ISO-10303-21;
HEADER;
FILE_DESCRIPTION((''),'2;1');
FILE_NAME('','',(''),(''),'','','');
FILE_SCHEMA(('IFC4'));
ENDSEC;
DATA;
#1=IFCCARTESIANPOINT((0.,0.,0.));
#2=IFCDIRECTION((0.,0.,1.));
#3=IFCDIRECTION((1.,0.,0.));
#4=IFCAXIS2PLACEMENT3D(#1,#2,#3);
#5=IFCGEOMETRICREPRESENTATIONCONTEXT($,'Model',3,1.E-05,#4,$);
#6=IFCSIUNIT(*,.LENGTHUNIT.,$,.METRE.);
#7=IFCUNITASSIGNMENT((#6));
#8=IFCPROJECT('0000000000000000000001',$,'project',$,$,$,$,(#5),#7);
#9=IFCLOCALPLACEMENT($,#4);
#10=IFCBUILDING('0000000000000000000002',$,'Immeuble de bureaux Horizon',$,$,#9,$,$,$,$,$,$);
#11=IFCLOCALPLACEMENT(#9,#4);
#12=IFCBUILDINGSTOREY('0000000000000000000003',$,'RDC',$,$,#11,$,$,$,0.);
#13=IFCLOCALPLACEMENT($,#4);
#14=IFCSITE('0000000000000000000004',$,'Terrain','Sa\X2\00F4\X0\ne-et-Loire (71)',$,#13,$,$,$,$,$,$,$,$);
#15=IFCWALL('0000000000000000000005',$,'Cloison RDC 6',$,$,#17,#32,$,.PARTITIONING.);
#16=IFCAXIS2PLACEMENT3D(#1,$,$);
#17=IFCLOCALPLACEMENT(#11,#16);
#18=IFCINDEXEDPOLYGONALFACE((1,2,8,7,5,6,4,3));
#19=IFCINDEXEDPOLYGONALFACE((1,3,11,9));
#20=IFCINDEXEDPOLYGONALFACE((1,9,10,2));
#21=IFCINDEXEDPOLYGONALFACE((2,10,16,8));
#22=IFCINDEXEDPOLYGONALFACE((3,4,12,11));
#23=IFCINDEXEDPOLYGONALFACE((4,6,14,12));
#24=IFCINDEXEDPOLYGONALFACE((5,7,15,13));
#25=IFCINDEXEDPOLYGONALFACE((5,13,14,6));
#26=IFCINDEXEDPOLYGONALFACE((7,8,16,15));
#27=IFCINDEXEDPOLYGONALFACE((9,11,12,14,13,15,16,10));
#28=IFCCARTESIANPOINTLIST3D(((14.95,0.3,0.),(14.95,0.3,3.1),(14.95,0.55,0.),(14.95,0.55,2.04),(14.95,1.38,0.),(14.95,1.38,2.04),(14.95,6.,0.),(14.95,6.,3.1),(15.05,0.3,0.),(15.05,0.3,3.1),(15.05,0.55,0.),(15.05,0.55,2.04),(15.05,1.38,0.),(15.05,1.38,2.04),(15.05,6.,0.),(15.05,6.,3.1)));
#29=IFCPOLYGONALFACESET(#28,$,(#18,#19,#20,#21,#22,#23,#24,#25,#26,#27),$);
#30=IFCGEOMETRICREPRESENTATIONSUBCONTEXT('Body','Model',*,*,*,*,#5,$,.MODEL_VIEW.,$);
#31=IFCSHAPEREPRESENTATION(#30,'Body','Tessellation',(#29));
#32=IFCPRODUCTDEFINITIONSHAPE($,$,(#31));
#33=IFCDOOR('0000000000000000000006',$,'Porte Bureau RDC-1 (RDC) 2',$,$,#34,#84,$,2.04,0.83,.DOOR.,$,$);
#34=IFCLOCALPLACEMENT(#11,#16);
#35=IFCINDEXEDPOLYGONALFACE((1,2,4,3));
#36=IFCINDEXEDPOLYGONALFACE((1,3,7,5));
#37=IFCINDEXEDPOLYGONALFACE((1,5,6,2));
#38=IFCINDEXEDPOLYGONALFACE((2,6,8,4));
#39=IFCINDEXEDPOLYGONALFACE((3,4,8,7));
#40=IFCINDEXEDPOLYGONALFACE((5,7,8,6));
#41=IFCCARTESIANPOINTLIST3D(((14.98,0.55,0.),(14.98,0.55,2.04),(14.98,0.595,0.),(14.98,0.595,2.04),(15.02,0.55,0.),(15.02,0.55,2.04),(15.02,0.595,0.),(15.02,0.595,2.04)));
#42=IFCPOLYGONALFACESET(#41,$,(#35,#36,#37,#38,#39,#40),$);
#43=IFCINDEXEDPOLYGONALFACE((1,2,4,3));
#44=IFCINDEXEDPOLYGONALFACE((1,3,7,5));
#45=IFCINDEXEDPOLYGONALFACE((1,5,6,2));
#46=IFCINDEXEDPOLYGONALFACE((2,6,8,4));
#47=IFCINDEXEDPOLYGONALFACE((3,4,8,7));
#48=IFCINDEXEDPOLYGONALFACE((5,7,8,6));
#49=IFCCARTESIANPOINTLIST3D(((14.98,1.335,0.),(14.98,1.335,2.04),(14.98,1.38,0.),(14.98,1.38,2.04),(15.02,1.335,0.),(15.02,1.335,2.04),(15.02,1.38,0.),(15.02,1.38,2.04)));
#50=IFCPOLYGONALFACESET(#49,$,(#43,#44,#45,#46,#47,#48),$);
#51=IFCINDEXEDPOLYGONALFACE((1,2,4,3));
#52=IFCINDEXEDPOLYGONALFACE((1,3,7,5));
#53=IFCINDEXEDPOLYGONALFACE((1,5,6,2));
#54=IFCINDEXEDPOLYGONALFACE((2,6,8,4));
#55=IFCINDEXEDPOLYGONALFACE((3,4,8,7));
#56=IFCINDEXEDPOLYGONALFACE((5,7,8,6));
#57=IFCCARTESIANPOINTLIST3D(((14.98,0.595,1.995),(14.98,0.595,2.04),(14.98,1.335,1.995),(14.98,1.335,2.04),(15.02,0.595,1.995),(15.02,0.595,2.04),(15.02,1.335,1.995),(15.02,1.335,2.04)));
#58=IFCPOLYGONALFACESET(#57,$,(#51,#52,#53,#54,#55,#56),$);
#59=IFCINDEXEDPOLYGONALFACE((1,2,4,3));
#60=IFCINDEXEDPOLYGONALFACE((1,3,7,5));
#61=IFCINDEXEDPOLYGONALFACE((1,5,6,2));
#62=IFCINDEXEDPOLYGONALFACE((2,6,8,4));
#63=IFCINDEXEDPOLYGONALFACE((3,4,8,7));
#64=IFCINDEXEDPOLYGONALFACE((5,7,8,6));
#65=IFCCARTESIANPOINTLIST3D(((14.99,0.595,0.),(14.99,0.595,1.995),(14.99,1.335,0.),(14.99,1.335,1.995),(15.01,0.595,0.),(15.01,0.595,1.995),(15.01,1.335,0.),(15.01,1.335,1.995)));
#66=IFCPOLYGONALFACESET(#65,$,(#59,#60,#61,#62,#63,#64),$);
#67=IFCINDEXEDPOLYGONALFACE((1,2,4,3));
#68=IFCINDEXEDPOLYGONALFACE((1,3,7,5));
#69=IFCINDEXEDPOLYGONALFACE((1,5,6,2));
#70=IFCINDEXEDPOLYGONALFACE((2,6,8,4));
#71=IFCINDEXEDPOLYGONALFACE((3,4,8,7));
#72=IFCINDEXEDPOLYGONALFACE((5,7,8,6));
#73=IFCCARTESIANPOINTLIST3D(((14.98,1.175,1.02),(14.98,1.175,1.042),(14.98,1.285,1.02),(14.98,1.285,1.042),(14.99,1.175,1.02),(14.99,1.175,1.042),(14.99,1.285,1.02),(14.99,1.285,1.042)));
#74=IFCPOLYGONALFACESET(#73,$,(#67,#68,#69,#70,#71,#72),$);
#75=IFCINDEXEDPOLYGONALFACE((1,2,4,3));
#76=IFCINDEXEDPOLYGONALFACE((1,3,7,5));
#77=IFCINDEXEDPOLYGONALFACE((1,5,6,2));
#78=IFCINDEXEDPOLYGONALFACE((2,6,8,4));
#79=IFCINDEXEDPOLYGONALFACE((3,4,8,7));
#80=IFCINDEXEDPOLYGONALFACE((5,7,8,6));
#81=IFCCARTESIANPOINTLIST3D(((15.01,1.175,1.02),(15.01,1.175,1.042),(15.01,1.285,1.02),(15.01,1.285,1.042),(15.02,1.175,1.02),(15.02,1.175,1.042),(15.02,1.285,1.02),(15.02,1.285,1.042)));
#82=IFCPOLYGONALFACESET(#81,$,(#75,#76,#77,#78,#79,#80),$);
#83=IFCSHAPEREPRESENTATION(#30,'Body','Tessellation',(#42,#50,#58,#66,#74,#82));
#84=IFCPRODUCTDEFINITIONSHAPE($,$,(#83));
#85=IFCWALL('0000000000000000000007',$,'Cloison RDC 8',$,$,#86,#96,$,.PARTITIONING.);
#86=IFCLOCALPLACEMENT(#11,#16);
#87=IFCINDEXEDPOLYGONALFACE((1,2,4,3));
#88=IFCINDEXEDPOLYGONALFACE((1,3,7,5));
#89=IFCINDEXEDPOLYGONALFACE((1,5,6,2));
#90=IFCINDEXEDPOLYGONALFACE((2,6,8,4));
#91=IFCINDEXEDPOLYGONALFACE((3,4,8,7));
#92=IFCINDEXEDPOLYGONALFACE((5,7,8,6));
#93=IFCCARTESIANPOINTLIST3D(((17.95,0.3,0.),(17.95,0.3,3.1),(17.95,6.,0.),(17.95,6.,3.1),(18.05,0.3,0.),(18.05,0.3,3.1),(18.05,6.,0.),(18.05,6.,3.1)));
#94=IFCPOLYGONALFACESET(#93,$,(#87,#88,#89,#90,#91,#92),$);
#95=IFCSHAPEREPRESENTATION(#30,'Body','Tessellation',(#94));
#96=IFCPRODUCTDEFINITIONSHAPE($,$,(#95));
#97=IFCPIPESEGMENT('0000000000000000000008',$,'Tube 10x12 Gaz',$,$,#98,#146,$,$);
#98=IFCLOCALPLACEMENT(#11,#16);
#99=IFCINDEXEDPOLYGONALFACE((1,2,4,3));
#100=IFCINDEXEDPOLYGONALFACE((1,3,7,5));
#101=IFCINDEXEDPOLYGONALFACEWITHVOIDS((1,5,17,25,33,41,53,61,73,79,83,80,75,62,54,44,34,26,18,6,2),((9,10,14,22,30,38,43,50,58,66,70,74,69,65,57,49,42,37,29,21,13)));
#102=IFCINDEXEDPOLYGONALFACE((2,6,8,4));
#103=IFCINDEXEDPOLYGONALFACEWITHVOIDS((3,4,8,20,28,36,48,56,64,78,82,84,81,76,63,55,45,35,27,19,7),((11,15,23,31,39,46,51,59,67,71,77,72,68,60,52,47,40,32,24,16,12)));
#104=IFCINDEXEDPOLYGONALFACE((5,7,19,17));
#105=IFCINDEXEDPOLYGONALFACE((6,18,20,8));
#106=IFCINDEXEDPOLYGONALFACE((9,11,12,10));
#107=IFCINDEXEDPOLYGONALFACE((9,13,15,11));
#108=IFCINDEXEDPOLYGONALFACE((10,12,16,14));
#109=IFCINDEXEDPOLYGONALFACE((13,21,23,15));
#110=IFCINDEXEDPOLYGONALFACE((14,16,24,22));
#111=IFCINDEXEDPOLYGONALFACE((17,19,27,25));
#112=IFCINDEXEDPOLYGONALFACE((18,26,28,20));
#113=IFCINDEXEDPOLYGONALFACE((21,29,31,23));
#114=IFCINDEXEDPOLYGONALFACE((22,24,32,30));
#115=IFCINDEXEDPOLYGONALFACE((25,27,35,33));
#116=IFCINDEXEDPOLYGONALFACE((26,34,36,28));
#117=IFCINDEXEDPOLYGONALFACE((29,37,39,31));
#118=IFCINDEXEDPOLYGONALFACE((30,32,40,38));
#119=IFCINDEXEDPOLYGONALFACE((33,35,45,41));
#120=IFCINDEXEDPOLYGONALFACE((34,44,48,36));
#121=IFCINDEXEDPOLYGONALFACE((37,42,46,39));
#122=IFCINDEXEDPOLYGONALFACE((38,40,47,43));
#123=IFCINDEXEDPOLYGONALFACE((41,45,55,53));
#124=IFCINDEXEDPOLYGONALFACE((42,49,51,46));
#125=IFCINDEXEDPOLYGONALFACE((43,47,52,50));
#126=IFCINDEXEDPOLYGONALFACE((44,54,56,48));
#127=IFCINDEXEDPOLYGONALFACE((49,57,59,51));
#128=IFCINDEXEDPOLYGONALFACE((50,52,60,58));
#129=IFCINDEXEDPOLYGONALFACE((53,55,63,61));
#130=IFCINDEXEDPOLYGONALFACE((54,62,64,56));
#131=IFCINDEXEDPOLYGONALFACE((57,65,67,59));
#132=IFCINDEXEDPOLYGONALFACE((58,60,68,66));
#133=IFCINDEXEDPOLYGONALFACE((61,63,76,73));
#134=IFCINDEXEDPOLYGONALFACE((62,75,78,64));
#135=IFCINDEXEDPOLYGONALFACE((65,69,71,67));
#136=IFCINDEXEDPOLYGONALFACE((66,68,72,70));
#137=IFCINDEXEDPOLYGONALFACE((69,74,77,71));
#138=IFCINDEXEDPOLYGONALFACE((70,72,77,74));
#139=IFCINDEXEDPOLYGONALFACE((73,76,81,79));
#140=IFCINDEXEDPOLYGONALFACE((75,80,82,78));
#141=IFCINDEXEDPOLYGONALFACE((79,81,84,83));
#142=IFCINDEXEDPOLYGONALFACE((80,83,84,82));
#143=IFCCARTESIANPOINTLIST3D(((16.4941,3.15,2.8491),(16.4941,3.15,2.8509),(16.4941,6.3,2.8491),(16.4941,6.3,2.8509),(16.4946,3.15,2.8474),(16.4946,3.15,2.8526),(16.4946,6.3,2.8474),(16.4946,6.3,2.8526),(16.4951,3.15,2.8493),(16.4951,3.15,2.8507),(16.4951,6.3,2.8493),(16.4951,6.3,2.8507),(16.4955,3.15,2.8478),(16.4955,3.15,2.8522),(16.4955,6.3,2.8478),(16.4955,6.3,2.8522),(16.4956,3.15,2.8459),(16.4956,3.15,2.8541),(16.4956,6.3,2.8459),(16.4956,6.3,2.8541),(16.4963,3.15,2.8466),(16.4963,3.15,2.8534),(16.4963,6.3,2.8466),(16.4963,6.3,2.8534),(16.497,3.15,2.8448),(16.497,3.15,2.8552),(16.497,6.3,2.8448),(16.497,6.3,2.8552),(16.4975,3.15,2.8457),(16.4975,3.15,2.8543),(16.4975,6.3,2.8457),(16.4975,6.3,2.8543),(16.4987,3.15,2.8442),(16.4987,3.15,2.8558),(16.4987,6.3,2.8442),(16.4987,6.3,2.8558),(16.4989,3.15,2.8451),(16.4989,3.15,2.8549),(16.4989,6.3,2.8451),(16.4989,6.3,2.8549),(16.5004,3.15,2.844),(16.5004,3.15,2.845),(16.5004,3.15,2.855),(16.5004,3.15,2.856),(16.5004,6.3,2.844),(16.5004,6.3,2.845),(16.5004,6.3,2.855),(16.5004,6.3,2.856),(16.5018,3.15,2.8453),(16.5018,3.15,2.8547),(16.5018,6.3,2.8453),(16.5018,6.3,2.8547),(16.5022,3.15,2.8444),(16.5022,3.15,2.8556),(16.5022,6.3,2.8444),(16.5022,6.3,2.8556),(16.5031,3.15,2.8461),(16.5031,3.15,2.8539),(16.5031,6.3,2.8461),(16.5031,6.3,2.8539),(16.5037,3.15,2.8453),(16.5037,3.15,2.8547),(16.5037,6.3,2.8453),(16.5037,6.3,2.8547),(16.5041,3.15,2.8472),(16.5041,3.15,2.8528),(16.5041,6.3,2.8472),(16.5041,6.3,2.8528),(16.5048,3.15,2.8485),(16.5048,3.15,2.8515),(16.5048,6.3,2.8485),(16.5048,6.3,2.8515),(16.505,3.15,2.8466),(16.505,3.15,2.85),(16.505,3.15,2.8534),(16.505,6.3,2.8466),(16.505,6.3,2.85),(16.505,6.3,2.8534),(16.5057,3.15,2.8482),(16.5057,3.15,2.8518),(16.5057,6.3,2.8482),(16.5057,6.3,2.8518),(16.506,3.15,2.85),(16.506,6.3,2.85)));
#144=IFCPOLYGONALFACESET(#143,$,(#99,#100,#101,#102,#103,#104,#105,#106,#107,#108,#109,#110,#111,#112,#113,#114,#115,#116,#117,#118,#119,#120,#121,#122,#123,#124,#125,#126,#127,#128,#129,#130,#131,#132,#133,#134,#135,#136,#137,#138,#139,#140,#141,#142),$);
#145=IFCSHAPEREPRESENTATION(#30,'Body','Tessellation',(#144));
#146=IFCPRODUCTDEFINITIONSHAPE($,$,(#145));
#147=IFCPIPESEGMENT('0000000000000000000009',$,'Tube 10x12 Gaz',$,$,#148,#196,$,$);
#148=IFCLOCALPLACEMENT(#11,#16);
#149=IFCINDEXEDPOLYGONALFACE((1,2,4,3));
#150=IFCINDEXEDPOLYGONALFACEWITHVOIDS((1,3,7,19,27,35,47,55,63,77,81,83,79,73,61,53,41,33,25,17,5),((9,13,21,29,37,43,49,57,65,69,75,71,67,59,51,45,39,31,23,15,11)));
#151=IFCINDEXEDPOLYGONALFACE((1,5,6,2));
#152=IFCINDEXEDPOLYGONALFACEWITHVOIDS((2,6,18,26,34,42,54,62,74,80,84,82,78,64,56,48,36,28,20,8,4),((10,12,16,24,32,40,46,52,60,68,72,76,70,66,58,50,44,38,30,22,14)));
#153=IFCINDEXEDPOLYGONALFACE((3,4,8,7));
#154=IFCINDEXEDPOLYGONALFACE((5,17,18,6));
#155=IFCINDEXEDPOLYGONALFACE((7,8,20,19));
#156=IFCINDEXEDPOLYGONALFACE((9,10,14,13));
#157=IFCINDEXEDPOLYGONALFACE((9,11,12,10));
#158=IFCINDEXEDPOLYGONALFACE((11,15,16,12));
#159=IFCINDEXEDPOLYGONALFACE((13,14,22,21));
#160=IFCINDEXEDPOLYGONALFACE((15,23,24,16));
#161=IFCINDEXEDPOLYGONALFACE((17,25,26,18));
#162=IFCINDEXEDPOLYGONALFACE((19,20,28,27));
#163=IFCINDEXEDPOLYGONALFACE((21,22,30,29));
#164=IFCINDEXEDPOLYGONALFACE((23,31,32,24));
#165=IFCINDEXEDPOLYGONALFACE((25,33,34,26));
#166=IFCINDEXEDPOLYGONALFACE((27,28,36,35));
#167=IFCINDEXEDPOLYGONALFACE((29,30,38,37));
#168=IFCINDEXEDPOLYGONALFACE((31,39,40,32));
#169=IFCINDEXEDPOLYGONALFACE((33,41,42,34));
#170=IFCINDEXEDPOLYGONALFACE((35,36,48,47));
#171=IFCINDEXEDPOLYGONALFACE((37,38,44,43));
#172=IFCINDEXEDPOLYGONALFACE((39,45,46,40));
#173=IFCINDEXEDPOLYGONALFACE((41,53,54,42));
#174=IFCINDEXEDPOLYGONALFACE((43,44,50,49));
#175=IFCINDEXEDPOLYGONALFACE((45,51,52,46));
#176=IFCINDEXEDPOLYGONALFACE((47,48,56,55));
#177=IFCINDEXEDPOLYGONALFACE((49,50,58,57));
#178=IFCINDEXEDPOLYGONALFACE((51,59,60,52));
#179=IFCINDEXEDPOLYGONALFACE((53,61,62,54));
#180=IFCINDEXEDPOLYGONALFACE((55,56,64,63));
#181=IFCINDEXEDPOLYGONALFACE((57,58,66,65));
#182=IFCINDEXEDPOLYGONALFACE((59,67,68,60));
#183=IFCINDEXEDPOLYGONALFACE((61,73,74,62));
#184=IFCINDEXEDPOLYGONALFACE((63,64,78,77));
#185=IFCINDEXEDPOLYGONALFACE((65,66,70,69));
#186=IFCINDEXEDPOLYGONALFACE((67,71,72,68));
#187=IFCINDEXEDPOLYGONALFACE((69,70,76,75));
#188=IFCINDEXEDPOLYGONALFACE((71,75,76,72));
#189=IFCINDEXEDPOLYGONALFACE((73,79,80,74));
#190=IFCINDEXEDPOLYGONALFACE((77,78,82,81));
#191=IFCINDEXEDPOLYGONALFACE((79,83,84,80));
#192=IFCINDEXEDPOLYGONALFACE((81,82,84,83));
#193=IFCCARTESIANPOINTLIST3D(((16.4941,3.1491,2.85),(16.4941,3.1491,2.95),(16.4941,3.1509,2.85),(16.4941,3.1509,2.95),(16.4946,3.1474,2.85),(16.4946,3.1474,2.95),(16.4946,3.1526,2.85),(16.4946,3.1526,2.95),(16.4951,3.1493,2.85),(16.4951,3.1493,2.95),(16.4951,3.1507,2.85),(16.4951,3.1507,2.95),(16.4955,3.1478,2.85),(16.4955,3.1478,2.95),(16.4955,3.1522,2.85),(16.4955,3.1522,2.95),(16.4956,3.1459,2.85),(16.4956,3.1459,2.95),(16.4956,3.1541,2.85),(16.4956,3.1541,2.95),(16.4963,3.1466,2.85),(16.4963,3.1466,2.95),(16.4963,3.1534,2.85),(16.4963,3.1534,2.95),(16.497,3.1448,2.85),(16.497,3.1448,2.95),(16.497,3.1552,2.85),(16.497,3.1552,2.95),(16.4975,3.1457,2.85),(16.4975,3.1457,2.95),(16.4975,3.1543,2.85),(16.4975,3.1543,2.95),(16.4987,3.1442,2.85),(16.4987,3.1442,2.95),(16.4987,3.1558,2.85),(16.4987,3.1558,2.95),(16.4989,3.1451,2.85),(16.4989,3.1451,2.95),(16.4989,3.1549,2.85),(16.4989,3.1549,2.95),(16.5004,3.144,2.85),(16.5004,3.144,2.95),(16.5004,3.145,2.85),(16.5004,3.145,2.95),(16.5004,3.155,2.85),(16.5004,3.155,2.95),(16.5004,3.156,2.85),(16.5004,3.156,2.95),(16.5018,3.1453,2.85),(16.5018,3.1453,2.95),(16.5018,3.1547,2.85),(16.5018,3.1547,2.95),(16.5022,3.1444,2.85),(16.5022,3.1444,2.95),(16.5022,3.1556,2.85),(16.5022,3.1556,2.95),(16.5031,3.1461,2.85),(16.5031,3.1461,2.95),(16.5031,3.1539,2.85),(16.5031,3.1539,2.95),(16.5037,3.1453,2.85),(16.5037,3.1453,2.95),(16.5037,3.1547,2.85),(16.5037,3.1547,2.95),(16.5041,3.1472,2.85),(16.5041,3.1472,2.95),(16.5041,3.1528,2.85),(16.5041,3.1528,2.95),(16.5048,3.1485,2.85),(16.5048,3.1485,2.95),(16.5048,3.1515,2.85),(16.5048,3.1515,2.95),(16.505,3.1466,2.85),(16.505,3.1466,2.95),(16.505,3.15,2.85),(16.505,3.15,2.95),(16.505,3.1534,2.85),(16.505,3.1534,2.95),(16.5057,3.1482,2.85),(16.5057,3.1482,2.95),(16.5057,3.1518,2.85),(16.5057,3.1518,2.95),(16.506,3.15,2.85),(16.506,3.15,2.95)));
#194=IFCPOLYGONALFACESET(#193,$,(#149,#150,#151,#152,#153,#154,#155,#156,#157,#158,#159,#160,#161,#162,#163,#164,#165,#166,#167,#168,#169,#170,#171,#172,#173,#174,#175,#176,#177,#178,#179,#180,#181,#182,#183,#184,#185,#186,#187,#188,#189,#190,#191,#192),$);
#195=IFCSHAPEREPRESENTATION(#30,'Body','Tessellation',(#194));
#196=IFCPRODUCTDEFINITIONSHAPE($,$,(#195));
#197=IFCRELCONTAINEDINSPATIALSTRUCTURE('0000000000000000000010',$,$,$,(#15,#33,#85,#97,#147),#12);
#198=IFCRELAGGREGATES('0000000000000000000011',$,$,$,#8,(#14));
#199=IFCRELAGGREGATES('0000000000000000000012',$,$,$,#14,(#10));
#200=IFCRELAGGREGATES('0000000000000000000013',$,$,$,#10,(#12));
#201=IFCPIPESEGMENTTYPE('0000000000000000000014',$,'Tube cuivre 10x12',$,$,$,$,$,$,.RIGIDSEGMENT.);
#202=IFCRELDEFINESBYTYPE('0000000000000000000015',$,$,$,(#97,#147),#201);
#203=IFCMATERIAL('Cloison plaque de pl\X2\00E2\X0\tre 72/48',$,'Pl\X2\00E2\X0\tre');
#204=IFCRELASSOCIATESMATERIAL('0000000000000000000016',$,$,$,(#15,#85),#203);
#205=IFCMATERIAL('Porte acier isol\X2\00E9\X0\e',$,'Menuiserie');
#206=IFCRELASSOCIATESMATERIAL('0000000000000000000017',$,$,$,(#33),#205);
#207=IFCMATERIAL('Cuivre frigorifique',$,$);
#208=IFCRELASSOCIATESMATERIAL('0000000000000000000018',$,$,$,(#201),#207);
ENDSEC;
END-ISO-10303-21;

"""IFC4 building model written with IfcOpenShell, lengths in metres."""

from ifc_helpers import new_model, si_unit, frame, frame_2d, origin_with_axes, place, context, subcontext, project, spatial, rectangle, hollow_circle, extrude, material, type_object, element, fill, save


model = new_model("IFC4")

# Units and contexts
model_context = context("Model", 3, precision=1e-05, world=origin_with_axes())
body_context = subcontext(model_context, "Body", "Model", "MODEL_VIEW")
ifc_project = project(units=[si_unit("LENGTHUNIT", "METRE")], contexts=[model_context])

# Site, building, storey
site_placement = place(None, origin_with_axes())
site = spatial("IfcSite", under=ifc_project, at=site_placement, Name="Terrain", Description="Saône-et-Loire (71)")
building_placement = place(None, origin_with_axes())
building = spatial("IfcBuilding", under=site, at=building_placement, Name="Immeuble de bureaux Horizon")
storey_placement = place(building_placement, origin_with_axes())
storey = spatial("IfcBuildingStorey", under=building, at=storey_placement, Name="RDC", Elevation=0.0)

# Wall, opening, door
ifc_material_1 = material(Name="Cloison plaque de plâtre 72/48", Category="Plâtre")
wall_1_placement = place(storey_placement, frame((14.95, 0.3, 0.0), z_axis=(0.0, 0.0, 1.0), x_axis=(1.0, 0.0, 0.0)))
wall_1 = element("IfcWall", 1, at=wall_1_placement, inside=storey, material=ifc_material_1, Name="Cloison RDC 6", PredefinedType="PARTITIONING", context=body_context, shape_type="SweptSolid", body=[
    extrude(rectangle(XDim=0.1, YDim=5.7, at=frame_2d((0.05, 2.85))), origin_with_axes(), (0.0, 0.0, 1.0), 3.1),
])
opening_placement = place(storey_placement, frame((14.9, 0.55, 0.0), z_axis=(0.0, 0.0, 1.0), x_axis=(1.0, 0.0, 0.0)))
opening = element("IfcOpeningElement", 2, at=opening_placement, cuts=wall_1, context=body_context, shape_type="SweptSolid", body=[
    extrude(rectangle(XDim=0.2, YDim=0.83, at=frame_2d((0.1, 0.415))), origin_with_axes(), (0.0, 0.0, 1.0), 2.04),
])
ifc_material_2 = material(Name="Porte acier isolée", Category="Menuiserie")
door_placement = place(storey_placement, frame((14.98, 0.55, 0.0), z_axis=(0.0, 0.0, 1.0), x_axis=(1.0, 0.0, 0.0)))
door = element("IfcDoor", 3, at=door_placement, inside=storey, material=ifc_material_2, Name="Porte Bureau RDC-1 (RDC) 2", OverallHeight=2.04, OverallWidth=0.83, PredefinedType="DOOR", context=body_context, shape_type="SweptSolid", body=[
    extrude(rectangle(XDim=0.04, YDim=0.045, at=frame_2d((0.02, 0.0225))), origin_with_axes(), (0.0, 0.0, 1.0), 2.04),
    extrude(rectangle(XDim=0.04, YDim=0.045, at=frame_2d((0.02, 0.0225))), frame((0.0, 0.785, 0.0), z_axis=(0.0, 0.0, 1.0), x_axis=(1.0, 0.0, 0.0)), (0.0, 0.0, 1.0), 2.04),
    extrude(rectangle(XDim=0.04, YDim=0.74, at=frame_2d((0.02, 0.37))), frame((0.0, 0.045, 1.995), z_axis=(0.0, 0.0, 1.0), x_axis=(1.0, 0.0, 0.0)), (0.0, 0.0, 1.0), 0.045),
    extrude(rectangle(XDim=0.02, YDim=0.74, at=frame_2d((0.01, 0.37))), frame((0.01, 0.045, 0.0), z_axis=(0.0, 0.0, 1.0), x_axis=(1.0, 0.0, 0.0)), (0.0, 0.0, 1.0), 1.995),
    extrude(rectangle(XDim=0.01, YDim=0.11, at=frame_2d((0.005, 0.055))), frame((0.0, 0.625, 1.02), z_axis=(0.0, 0.0, 1.0), x_axis=(1.0, 0.0, 0.0)), (0.0, 0.0, 1.0), 0.022),
    extrude(rectangle(XDim=0.01, YDim=0.11, at=frame_2d((0.005, 0.055))), frame((0.03, 0.625, 1.02), z_axis=(0.0, 0.0, 1.0), x_axis=(1.0, 0.0, 0.0)), (0.0, 0.0, 1.0), 0.022),
])
fill(opening, door)

# Wall
wall_2_placement = place(storey_placement, frame((17.95, 0.3, 0.0), z_axis=(0.0, 0.0, 1.0), x_axis=(1.0, 0.0, 0.0)))
element("IfcWall", 4, at=wall_2_placement, inside=storey, material=ifc_material_1, Name="Cloison RDC 8", PredefinedType="PARTITIONING", context=body_context, shape_type="SweptSolid", body=[
    extrude(rectangle(XDim=0.1, YDim=5.7, at=frame_2d((0.05, 2.85))), origin_with_axes(), (0.0, 0.0, 1.0), 3.1),
])

# Pipe segments
ifc_material_3 = material(Name="Cuivre frigorifique")
pipe_segment_type_1 = type_object("IfcPipeSegmentType", Name="Tube cuivre 10x12", PredefinedType="RIGIDSEGMENT", material=ifc_material_3)
pipe_segment_1_placement = place(storey_placement, frame((16.5, 6.3, 2.85), z_axis=(0.0, -1.0, 0.0), x_axis=(1.0, 0.0, 0.0)))
element("IfcPipeSegment", 5, at=pipe_segment_1_placement, inside=storey, type_object=pipe_segment_type_1, Name="Tube 10x12 Gaz", context=body_context, shape_type="SweptSolid", body=[
    extrude(hollow_circle(Radius=0.006, WallThickness=0.001), origin_with_axes(), (0.0, 0.0, 1.0), 3.15),
])
pipe_segment_2_placement = place(storey_placement, frame((16.5, 3.15, 2.85), z_axis=(0.0, 0.0, 1.0), x_axis=(1.0, 0.0, 0.0)))
element("IfcPipeSegment", 6, at=pipe_segment_2_placement, inside=storey, type_object=pipe_segment_type_1, Name="Tube 10x12 Gaz", context=body_context, shape_type="SweptSolid", body=[
    extrude(hollow_circle(Radius=0.006, WallThickness=0.001), origin_with_axes(), (0.0, 0.0, 1.0), 0.1),
])

save(model, "model.ifc")
